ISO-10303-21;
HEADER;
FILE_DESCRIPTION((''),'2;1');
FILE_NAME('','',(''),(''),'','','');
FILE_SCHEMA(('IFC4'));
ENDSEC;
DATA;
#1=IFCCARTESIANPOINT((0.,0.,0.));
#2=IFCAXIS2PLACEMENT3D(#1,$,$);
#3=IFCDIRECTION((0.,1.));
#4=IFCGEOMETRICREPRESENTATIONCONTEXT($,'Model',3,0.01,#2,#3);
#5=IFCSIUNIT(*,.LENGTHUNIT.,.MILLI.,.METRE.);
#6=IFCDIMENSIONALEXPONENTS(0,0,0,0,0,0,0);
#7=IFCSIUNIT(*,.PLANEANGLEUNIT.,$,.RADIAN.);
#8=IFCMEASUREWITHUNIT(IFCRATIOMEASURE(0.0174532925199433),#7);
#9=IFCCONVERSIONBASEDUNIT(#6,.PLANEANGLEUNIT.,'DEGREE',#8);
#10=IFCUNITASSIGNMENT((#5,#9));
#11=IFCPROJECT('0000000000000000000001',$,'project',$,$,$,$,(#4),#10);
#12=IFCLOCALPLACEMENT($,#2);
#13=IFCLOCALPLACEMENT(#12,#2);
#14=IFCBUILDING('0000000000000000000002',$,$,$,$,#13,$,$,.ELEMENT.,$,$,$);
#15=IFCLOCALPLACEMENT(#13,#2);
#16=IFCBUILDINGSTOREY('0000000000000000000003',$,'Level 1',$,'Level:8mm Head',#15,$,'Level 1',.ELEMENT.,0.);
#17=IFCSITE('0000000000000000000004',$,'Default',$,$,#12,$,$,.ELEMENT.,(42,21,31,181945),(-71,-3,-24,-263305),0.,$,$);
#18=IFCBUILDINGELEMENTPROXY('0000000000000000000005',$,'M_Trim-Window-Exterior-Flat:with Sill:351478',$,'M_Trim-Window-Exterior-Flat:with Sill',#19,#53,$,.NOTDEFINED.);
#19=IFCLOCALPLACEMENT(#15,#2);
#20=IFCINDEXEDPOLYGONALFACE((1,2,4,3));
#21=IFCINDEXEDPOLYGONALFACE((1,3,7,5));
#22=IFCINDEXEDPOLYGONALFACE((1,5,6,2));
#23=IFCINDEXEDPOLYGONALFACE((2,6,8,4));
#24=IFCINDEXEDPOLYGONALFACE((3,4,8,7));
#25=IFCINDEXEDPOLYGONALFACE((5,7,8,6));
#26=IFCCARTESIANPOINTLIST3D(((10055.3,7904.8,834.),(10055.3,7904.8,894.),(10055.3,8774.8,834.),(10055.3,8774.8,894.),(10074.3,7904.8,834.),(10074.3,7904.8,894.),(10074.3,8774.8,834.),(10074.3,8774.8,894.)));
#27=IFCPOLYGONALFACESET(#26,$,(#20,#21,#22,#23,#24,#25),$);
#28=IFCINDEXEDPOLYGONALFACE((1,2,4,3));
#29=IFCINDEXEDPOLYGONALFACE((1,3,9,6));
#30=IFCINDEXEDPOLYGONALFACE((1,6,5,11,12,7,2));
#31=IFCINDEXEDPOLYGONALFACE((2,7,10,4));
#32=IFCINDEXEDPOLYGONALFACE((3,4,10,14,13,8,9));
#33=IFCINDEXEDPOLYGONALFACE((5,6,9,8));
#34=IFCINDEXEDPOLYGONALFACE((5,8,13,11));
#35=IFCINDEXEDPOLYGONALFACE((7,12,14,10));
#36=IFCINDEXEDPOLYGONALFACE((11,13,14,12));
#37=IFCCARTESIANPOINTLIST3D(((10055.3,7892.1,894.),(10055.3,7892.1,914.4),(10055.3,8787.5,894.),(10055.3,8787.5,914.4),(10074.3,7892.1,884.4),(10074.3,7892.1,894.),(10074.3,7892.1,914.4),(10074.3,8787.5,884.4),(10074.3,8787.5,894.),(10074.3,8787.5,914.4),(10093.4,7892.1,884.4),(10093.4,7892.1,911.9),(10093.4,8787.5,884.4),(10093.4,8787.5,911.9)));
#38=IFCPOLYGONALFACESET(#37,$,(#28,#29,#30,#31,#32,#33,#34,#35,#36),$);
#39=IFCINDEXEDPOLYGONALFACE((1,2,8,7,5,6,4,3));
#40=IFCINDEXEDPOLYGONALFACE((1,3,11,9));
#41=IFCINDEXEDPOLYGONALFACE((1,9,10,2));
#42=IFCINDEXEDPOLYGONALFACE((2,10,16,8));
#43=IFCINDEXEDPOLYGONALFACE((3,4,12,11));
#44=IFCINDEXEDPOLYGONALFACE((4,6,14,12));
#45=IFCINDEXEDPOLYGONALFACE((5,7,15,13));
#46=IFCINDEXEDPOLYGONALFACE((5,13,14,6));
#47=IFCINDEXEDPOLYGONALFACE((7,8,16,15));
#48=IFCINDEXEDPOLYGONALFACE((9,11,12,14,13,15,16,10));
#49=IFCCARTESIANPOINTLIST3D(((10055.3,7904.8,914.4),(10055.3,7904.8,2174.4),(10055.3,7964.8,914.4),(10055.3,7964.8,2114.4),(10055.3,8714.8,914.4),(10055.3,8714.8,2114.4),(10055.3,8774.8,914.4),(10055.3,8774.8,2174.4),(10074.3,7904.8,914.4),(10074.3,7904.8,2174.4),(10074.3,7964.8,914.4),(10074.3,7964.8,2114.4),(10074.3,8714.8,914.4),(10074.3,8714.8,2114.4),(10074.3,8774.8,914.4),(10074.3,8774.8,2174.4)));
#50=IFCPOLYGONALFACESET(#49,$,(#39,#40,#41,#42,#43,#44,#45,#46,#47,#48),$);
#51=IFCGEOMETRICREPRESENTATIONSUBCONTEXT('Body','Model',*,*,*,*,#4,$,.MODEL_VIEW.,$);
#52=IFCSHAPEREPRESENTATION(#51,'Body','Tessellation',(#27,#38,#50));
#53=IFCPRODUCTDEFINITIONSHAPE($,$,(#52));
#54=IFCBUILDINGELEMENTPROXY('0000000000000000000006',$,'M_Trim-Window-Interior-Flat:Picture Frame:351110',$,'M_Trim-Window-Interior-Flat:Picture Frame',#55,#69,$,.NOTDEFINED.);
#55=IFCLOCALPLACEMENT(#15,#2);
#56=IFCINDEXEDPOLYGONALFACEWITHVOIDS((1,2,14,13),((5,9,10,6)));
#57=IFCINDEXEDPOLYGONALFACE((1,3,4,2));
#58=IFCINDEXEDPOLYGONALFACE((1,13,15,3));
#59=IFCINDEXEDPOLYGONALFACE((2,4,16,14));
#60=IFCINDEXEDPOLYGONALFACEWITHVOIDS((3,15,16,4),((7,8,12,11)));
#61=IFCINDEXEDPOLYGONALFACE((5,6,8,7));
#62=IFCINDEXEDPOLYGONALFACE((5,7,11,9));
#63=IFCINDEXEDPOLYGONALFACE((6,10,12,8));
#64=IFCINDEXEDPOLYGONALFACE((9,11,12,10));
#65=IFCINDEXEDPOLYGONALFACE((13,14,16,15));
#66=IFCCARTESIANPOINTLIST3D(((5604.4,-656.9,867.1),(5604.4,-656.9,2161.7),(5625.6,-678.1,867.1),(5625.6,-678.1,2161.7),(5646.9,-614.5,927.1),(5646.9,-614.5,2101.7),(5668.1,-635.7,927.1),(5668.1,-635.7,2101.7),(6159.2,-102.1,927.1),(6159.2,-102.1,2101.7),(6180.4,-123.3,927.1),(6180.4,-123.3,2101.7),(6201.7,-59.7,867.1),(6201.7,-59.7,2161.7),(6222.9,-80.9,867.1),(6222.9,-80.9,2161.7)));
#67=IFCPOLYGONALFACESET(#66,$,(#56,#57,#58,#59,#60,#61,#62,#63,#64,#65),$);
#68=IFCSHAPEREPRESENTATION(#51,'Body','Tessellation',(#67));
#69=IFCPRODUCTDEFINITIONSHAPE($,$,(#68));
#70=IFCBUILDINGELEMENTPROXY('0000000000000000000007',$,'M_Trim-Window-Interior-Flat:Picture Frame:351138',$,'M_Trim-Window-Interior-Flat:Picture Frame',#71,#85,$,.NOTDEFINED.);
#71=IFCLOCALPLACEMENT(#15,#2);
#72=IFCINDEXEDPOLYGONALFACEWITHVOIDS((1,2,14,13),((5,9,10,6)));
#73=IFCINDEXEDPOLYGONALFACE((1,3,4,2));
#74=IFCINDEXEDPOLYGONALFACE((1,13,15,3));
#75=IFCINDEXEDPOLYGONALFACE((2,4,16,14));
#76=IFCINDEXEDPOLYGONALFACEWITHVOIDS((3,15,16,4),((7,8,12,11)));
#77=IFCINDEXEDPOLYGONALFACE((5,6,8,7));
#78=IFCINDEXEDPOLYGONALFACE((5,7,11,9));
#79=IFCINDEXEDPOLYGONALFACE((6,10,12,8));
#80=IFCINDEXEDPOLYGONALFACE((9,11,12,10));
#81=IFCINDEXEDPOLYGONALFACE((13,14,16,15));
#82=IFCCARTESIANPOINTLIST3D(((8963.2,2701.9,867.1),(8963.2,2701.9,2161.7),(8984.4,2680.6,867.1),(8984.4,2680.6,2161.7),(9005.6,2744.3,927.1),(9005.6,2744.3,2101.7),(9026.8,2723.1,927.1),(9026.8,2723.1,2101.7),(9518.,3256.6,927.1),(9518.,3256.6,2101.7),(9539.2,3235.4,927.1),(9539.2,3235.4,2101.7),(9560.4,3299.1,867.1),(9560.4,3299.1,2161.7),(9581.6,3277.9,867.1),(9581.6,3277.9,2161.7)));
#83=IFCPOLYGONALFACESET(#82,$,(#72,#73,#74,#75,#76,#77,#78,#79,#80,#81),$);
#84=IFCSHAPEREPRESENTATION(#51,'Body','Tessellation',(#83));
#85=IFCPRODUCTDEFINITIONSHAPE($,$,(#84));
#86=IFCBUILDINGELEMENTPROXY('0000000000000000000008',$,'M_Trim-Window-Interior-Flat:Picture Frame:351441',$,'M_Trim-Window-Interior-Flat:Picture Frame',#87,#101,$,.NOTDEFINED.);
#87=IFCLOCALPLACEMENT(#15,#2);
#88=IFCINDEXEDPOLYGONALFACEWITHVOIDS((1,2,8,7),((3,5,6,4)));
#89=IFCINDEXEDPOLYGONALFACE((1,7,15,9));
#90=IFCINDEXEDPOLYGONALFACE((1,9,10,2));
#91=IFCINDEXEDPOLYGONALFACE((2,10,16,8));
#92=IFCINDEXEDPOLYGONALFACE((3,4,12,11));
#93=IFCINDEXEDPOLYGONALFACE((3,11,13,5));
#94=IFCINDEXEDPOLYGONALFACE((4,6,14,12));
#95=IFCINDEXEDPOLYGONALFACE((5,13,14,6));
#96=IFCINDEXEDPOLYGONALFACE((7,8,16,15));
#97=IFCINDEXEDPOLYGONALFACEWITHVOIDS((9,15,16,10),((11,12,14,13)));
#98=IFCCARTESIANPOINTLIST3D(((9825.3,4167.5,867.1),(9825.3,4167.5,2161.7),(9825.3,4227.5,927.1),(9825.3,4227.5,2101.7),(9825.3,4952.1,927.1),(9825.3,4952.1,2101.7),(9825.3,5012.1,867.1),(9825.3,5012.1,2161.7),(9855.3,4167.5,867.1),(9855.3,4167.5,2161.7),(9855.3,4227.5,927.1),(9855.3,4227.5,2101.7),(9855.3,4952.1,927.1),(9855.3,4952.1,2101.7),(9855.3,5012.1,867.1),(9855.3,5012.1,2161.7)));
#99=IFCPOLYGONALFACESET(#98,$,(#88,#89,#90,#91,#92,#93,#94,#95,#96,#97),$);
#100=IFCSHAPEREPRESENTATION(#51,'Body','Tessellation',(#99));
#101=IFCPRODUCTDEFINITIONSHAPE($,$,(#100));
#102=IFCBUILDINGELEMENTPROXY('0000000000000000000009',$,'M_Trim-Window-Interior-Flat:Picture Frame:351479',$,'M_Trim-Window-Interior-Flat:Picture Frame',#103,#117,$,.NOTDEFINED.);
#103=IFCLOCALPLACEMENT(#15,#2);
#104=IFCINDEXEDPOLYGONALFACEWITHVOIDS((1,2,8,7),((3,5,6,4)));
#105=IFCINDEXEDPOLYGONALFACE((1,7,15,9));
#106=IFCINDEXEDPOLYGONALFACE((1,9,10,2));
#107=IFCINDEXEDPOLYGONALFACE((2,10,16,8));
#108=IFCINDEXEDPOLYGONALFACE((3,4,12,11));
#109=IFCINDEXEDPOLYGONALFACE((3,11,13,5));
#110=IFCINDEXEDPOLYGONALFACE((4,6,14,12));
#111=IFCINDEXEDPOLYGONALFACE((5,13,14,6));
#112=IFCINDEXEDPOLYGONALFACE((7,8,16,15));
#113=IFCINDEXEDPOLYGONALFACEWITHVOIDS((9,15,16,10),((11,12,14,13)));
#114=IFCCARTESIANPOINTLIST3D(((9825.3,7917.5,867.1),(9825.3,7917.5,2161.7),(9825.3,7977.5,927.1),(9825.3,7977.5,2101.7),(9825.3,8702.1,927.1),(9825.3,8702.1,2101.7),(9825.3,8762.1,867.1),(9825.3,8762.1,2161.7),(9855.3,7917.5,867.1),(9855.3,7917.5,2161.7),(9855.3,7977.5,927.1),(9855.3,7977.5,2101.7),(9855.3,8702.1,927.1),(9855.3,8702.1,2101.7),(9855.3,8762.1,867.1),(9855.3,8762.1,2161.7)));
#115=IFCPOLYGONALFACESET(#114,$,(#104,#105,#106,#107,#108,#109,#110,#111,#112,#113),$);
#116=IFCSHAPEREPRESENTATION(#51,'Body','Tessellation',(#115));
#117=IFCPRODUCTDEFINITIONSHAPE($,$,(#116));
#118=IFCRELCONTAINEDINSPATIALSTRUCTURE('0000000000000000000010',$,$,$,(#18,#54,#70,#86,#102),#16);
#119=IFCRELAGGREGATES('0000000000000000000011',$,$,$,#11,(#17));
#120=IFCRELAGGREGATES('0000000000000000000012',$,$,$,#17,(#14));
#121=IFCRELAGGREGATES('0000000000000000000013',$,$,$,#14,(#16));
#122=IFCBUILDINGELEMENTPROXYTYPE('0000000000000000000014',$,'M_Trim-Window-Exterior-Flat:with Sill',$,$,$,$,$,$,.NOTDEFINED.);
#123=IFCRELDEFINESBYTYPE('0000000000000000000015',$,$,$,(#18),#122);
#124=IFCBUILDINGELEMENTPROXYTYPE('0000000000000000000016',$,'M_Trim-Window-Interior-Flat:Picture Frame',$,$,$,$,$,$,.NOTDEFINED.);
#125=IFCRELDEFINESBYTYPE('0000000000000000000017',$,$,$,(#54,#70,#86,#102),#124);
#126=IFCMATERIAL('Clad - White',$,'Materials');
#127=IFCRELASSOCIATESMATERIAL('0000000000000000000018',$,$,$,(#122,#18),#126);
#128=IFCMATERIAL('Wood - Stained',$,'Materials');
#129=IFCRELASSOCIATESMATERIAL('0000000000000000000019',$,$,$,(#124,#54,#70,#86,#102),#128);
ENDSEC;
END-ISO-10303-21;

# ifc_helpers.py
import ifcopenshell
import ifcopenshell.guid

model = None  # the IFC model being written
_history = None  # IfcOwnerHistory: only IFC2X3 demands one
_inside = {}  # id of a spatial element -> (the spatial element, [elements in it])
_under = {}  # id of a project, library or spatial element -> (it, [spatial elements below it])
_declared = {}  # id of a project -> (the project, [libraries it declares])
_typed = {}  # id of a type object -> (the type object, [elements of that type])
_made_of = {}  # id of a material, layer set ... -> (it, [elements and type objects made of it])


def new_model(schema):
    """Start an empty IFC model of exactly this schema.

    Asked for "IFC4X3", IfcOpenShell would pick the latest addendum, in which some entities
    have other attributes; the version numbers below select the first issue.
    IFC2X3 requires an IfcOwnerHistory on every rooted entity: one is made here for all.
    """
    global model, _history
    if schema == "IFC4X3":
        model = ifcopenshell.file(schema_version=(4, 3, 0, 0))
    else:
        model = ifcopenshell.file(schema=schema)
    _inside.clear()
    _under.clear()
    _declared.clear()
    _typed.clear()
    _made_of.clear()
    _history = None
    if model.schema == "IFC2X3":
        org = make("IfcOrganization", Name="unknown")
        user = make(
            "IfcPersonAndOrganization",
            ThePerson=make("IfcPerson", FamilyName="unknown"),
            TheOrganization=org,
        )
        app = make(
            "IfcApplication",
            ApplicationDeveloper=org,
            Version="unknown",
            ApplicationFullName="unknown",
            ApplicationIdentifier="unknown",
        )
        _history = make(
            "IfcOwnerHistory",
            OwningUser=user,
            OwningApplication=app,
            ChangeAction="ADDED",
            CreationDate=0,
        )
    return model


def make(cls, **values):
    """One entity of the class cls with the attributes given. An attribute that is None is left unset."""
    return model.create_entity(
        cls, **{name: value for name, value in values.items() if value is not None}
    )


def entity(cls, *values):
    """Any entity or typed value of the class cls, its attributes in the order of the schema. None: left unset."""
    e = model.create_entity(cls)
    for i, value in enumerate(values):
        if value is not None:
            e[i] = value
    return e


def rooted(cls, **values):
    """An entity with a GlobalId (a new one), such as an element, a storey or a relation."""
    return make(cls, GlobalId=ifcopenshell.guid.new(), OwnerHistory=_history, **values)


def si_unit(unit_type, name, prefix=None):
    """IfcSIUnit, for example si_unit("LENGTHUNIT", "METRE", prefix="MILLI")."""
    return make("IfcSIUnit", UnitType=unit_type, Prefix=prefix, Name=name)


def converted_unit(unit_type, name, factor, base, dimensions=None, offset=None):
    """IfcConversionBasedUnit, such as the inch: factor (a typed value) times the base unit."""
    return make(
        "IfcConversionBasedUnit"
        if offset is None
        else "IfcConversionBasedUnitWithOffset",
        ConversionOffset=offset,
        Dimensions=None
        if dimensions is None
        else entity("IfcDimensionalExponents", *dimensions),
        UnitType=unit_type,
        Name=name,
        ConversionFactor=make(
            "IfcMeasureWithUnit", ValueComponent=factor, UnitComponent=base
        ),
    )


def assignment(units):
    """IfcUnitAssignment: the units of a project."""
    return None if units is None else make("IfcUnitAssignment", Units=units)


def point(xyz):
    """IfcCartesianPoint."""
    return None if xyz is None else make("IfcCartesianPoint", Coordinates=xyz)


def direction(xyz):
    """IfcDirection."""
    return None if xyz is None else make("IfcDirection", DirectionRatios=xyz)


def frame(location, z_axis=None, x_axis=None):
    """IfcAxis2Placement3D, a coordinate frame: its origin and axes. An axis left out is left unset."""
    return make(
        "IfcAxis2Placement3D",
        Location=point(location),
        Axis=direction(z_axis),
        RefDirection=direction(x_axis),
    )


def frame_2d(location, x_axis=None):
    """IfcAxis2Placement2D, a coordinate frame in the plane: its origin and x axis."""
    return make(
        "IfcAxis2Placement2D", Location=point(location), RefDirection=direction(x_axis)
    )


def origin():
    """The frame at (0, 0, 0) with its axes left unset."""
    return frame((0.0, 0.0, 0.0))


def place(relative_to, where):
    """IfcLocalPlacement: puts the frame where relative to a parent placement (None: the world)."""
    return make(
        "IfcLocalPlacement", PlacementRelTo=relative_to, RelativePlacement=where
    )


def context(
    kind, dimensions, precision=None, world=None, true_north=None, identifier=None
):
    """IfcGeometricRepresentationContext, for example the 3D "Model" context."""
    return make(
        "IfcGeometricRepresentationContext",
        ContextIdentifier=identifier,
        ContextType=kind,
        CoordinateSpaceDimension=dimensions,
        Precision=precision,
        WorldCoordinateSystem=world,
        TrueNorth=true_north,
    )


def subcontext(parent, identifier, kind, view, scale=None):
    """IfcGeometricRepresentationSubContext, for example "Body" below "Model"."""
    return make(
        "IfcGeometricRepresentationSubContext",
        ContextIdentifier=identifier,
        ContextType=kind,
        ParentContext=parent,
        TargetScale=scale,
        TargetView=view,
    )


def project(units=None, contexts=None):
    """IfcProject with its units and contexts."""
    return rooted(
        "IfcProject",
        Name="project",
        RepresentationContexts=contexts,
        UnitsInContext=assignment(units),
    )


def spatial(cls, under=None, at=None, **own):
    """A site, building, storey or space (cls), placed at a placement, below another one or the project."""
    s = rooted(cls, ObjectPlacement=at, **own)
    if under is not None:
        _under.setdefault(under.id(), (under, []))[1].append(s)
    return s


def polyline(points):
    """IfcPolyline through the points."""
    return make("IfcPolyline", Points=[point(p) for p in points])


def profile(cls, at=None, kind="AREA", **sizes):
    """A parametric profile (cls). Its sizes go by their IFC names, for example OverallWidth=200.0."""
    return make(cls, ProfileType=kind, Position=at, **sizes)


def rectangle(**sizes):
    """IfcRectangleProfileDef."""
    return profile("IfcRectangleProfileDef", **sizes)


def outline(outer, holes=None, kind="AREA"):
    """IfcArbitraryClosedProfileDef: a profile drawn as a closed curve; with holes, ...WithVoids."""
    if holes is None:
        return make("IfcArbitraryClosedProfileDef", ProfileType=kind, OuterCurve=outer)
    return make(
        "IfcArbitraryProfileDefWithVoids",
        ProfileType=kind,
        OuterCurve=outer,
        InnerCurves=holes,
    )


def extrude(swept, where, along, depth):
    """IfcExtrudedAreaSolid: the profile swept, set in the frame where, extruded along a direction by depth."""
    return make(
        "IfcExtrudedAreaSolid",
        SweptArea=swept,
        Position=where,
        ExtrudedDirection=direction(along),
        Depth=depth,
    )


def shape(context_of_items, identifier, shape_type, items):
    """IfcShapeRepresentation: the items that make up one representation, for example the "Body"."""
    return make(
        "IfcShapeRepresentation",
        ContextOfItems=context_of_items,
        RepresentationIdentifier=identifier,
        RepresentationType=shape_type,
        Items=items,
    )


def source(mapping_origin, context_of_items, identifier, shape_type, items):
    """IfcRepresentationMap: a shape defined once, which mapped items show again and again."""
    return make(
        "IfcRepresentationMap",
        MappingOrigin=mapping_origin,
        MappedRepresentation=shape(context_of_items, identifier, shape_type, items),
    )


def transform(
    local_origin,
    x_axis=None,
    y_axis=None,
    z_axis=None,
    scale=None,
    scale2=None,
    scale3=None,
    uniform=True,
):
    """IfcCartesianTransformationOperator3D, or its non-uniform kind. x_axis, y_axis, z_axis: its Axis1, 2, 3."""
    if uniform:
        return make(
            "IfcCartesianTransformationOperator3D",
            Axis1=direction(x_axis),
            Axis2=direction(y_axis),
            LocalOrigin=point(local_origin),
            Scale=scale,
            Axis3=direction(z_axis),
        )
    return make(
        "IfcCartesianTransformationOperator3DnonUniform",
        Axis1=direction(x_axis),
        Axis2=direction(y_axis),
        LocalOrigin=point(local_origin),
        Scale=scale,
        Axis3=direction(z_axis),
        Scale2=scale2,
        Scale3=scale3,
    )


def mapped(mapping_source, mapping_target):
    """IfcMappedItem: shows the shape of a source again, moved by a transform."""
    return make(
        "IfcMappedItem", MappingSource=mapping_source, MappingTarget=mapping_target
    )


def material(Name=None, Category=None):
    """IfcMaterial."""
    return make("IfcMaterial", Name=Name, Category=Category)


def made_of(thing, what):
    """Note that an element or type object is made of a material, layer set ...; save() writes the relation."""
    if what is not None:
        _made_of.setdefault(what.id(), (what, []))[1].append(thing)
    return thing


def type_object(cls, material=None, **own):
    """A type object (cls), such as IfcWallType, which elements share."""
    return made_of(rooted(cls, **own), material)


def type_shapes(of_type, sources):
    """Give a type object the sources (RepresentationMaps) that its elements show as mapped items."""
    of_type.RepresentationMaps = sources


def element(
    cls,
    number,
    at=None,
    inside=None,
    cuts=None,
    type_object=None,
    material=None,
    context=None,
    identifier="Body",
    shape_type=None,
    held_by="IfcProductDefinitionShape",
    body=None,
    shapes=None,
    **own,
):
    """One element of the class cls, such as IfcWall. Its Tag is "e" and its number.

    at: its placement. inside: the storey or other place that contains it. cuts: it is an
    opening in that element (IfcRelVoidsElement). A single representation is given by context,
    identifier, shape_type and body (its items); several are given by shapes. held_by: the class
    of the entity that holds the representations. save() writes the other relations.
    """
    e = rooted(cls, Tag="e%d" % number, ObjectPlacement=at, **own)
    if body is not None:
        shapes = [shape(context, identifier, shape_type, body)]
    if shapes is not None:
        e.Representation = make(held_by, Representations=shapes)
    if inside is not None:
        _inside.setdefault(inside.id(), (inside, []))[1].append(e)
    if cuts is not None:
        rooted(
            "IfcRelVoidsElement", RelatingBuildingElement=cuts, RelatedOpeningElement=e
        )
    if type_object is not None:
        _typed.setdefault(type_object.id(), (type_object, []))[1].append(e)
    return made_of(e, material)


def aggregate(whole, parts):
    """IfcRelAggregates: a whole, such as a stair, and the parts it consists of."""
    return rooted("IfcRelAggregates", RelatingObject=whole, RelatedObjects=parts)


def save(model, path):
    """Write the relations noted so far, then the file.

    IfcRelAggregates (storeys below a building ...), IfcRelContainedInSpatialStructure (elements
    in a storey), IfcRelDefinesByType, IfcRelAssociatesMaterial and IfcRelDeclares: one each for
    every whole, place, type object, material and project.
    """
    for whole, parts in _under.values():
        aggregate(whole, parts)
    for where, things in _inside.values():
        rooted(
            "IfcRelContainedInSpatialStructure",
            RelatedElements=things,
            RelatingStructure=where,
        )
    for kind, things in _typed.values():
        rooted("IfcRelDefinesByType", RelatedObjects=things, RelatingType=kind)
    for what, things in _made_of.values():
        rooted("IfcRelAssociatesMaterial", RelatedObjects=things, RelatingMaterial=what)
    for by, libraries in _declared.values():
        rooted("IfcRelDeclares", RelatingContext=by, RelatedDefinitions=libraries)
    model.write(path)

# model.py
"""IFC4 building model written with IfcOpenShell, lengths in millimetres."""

from ifc_helpers import new_model, entity, si_unit, converted_unit, direction, frame, frame_2d, origin, place, context, subcontext, project, spatial, polyline, rectangle, outline, extrude, source, transform, mapped, material, type_object, type_shapes, element, save


model = new_model("IFC4")

# Units and contexts
model_context = context("Model", 3, precision=0.01, world=origin(), true_north=direction((0.0, 1.0)))
body_context = subcontext(model_context, "Body", "Model", "MODEL_VIEW")
ifc_project = project(units=[si_unit("LENGTHUNIT", "METRE", prefix="MILLI"), converted_unit("PLANEANGLEUNIT", "DEGREE", entity("IfcRatioMeasure", 0.0174532925199433), si_unit("PLANEANGLEUNIT", "RADIAN"), dimensions=[0, 0, 0, 0, 0, 0, 0])], contexts=[model_context])

# Site, building, storey
site_placement = place(None, origin())
site = spatial("IfcSite", under=ifc_project, at=site_placement, Name="Default", CompositionType="ELEMENT", RefLatitude=(42, 21, 31, 181945), RefLongitude=(-71, -3, -24, -263305), RefElevation=0.0)
building_placement = place(site_placement, origin())
building = spatial("IfcBuilding", under=site, at=building_placement, CompositionType="ELEMENT")
storey_placement = place(building_placement, origin())
storey = spatial("IfcBuildingStorey", under=building, at=storey_placement, Name="Level 1", ObjectType="Level:8mm Head", LongName="Level 1", CompositionType="ELEMENT", Elevation=0.0)

# Shared definitions
ifc_material_1 = material(Name="Wood - Stained", Category="Materials")

# Building element proxies
ifc_material_2 = material(Name="Clad - White", Category="Materials")
building_element_proxy_type_1 = type_object("IfcBuildingElementProxyType", Name="M_Trim-Window-Exterior-Flat:with Sill", PredefinedType="NOTDEFINED", material=ifc_material_2)
shared_shape_1 = source(origin(), body_context, "Body", "SweptSolid", [
    extrude(rectangle(XDim=870.0, YDim=60.0, at=frame_2d((0.0, 0.0), x_axis=(1.0, 0.0))), frame((0.0, -1250.4, 0.0), z_axis=(0.0, 0.0, 1.0), x_axis=(-1.0, 0.0, 0.0)), (0.0, 0.0, 1.0), 19.1),
    extrude(outline(polyline([(-19.0, -15.2), (0.0, -15.2), (0.0, -5.7), (19.0, -5.7), (19.0, 14.8), (0.0, 14.8), (-19.0, 12.3), (-19.0, -15.2)])), frame((-447.7, -1214.8, 19.0), z_axis=(1.0, 0.0, 0.0), x_axis=(0.0, 0.0, -1.0)), (0.0, 0.0, 1.0), 895.4),
    extrude(outline(polyline([(-645.0, -435.0), (615.0, -435.0), (615.0, -375.0), (-585.0, -375.0), (-585.0, 375.0), (615.0, 375.0), (615.0, 435.0), (-645.0, 435.0), (-645.0, -435.0)])), frame((0.0, -585.0, 0.0), z_axis=(0.0, 0.0, 1.0), x_axis=(0.0, -1.0, 0.0)), (0.0, 0.0, 1.0), 19.1),
])
type_shapes(building_element_proxy_type_1, [shared_shape_1])
for number, where, z_axis, x_axis, name in (
    (1, (10055.3, 8339.8, 2114.4), (1.0, 0.0, 0.0), (0.0, 1.0, 0.0), "M_Trim-Window-Exterior-Flat:with Sill:351478"),
):
    element("IfcBuildingElementProxy", number, at=place(storey_placement, frame(where, z_axis=z_axis, x_axis=x_axis)), inside=storey, type_object=building_element_proxy_type_1, material=ifc_material_2, Name=name, ObjectType="M_Trim-Window-Exterior-Flat:with Sill", PredefinedType="NOTDEFINED", context=body_context, shape_type="MappedRepresentation", body=[
        mapped(shared_shape_1, transform((0.0, 0.0, 0.0), scale=1.0)),
    ])
building_element_proxy_type_2 = type_object("IfcBuildingElementProxyType", Name="M_Trim-Window-Interior-Flat:Picture Frame", PredefinedType="NOTDEFINED", material=ifc_material_1)
shared_shape_2 = source(origin(), body_context, "Body", "SweptSolid", [
    extrude(outline(polyline([(-422.3, -647.3), (422.3, -647.3), (422.3, 647.3), (-422.3, 647.3), (-422.3, -647.3)]), holes=[polyline([(-362.3, -587.3), (-362.3, 587.3), (362.3, 587.3), (362.3, -587.3), (-362.3, -587.3)])]), frame((0.0, -600.0, 0.0), z_axis=(0.0, 0.0, 1.0), x_axis=(-1.0, 0.0, 0.0)), (0.0, 0.0, 1.0), 30.0),
])
type_shapes(building_element_proxy_type_2, [shared_shape_2])
for number, where, z_axis, x_axis, name in (
    (2, (5903.0, -358.3, 2114.4), (0.707107, -0.707107, 0.0), (0.707107, 0.707107, 0.0), "M_Trim-Window-Interior-Flat:Picture Frame:351110"),
    (3, (9261.8, 3000.5, 2114.4), (0.707107, -0.707107, 0.0), (0.707107, 0.707107, 0.0), "M_Trim-Window-Interior-Flat:Picture Frame:351138"),
    (4, (9855.3, 4589.8, 2114.4), (-1.0, 0.0, 0.0), (0.0, -1.0, 0.0), "M_Trim-Window-Interior-Flat:Picture Frame:351441"),
    (5, (9855.3, 8339.8, 2114.4), (-1.0, 0.0, 0.0), (0.0, -1.0, 0.0), "M_Trim-Window-Interior-Flat:Picture Frame:351479"),
):
    element("IfcBuildingElementProxy", number, at=place(storey_placement, frame(where, z_axis=z_axis, x_axis=x_axis)), inside=storey, type_object=building_element_proxy_type_2, material=ifc_material_1, Name=name, ObjectType="M_Trim-Window-Interior-Flat:Picture Frame", PredefinedType="NOTDEFINED", context=body_context, shape_type="MappedRepresentation", body=[
        mapped(shared_shape_2, transform((0.0, 0.0, 0.0), scale=1.0)),
    ])

save(model, "model.ifc")
